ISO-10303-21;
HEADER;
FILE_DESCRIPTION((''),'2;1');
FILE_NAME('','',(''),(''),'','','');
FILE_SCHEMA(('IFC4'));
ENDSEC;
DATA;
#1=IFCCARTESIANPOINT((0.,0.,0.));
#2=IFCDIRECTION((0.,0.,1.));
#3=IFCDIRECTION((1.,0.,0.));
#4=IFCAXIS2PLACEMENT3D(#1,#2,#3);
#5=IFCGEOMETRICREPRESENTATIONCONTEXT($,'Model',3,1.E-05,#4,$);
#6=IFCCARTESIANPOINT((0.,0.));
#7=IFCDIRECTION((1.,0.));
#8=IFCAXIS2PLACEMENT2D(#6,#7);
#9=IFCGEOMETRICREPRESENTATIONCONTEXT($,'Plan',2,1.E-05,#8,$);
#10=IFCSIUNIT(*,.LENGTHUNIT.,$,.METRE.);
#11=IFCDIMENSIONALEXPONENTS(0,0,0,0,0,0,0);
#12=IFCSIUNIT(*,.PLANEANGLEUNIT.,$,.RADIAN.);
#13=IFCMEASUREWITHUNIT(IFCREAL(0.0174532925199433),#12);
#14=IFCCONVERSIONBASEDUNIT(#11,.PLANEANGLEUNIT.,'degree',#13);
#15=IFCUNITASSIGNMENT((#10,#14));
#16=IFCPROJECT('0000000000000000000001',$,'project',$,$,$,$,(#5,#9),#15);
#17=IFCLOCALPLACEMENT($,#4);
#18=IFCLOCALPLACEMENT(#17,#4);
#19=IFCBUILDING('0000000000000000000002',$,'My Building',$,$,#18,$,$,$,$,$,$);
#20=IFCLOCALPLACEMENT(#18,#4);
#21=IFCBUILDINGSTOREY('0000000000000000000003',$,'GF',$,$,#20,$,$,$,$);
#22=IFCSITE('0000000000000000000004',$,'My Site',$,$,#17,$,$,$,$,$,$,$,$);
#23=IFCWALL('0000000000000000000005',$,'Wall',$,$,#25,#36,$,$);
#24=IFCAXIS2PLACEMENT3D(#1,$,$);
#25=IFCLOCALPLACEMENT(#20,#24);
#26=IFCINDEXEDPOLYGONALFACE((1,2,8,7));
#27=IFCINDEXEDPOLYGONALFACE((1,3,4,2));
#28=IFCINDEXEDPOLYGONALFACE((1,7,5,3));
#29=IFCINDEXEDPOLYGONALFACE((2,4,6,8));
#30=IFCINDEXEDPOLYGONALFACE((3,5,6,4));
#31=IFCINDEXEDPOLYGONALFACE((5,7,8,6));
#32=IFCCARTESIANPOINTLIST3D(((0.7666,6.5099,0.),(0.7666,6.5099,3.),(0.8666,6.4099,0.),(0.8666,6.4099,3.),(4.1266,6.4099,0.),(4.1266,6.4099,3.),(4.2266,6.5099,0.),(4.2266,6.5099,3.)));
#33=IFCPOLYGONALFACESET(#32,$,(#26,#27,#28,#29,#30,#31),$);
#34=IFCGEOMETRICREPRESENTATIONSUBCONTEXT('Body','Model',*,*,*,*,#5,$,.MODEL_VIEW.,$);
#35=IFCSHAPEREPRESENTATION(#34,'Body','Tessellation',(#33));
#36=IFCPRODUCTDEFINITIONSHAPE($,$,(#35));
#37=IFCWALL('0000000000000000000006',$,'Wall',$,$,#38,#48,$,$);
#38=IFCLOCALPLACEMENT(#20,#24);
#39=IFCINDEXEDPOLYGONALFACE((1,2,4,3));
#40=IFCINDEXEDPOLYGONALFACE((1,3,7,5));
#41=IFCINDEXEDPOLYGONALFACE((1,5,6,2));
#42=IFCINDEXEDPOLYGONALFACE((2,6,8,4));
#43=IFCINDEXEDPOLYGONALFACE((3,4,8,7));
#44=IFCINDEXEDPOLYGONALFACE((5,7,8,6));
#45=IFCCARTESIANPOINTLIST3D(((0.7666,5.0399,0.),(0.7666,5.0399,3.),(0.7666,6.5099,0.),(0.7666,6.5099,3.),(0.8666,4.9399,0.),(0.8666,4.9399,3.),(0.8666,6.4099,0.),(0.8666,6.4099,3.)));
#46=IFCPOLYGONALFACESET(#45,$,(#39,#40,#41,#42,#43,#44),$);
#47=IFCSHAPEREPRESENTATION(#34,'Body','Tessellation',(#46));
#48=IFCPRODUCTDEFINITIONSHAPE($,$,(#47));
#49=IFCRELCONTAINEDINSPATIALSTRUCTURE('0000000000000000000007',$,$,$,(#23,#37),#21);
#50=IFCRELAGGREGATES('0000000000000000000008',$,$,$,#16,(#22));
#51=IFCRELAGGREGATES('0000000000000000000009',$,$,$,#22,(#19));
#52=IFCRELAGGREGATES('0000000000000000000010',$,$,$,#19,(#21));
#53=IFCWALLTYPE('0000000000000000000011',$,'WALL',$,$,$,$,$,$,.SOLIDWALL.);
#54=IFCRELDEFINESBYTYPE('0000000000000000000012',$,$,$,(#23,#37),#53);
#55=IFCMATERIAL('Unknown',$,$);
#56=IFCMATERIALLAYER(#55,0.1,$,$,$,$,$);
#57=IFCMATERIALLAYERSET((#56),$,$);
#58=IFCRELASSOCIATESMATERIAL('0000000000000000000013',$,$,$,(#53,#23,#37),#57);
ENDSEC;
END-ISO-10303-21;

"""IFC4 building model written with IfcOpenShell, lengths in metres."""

from ifc_helpers import new_model, entity, si_unit, converted_unit, frame, origin_with_axes, origin_2d_with_axis, place, context, subcontext, project, spatial, line, indexed_curve, outline, extrude, material, layer, layer_set, layer_usage, type_object, element, save


model = new_model("IFC4")

# Units and contexts
model_context = context("Model", 3, precision=1e-05, world=origin_with_axes())
plan_context = context("Plan", 2, precision=1e-05, world=origin_2d_with_axis())
body_context_1 = subcontext(model_context, "Body", "Model", "MODEL_VIEW")
ifc_project = project(units=[si_unit("LENGTHUNIT", "METRE"), converted_unit("PLANEANGLEUNIT", "degree", entity("IfcReal", 0.0174532925199433), si_unit("PLANEANGLEUNIT", "RADIAN"), dimensions=[0, 0, 0, 0, 0, 0, 0])], contexts=[model_context, plan_context])

# Site, building, storey
site_placement = place(None, origin_with_axes())
site = spatial("IfcSite", under=ifc_project, at=site_placement, Name="My Site")
building_placement = place(site_placement, origin_with_axes())
building = spatial("IfcBuilding", under=site, at=building_placement, Name="My Building")
storey_placement = place(building_placement, origin_with_axes())
storey = spatial("IfcBuildingStorey", under=building, at=storey_placement, Name="GF")

# Walls
ifc_material_1 = material(Name="Unknown")
ifc_layer_1 = layer(ifc_material_1, 0.1)
ifc_layer_set_1 = layer_set([ifc_layer_1])
ifc_layer_usage_1 = layer_usage(ifc_layer_set_1, "AXIS2", "POSITIVE", 0.0)
wall_type = type_object("IfcWallType", Name="WALL", PredefinedType="SOLIDWALL", material=ifc_layer_set_1)
wall_1_placement = place(storey_placement, frame((4.2266, 6.5099, 0.0), z_axis=(0.0, 0.0, 1.0), x_axis=(-1.0, 0.0, 0.0)))
element("IfcWall", 1, at=wall_1_placement, inside=storey, type_object=wall_type, material=ifc_layer_usage_1, Name="Wall", context=body_context_1, shape_type="SweptSolid", body=[
    extrude(outline(indexed_curve([(0.0, 0.0), (0.1, 0.1), (3.36, 0.1), (3.46, 0.0)], segments=[line(1, 2, 3, 4, 1)])), origin_with_axes(), (0.0, 0.0, 1.0), 3.0),
])
ifc_layer_usage_2 = layer_usage(ifc_layer_set_1, "AXIS2", "POSITIVE", 0.0)
wall_2_placement = place(storey_placement, frame((0.7666, 6.5099, 0.0), z_axis=(0.0, 0.0, 1.0), x_axis=(0.0, -1.0, 0.0)))
element("IfcWall", 2, at=wall_2_placement, inside=storey, type_object=wall_type, material=ifc_layer_usage_2, Name="Wall", context=body_context_1, shape_type="SweptSolid", body=[
    extrude(outline(indexed_curve([(0.0, 0.0), (0.1, 0.1), (1.57, 0.1), (1.47, 0.0)], segments=[line(1, 2, 3, 4, 1)])), origin_with_axes(), (0.0, 0.0, 1.0), 3.0),
])

save(model, "model.ifc")
